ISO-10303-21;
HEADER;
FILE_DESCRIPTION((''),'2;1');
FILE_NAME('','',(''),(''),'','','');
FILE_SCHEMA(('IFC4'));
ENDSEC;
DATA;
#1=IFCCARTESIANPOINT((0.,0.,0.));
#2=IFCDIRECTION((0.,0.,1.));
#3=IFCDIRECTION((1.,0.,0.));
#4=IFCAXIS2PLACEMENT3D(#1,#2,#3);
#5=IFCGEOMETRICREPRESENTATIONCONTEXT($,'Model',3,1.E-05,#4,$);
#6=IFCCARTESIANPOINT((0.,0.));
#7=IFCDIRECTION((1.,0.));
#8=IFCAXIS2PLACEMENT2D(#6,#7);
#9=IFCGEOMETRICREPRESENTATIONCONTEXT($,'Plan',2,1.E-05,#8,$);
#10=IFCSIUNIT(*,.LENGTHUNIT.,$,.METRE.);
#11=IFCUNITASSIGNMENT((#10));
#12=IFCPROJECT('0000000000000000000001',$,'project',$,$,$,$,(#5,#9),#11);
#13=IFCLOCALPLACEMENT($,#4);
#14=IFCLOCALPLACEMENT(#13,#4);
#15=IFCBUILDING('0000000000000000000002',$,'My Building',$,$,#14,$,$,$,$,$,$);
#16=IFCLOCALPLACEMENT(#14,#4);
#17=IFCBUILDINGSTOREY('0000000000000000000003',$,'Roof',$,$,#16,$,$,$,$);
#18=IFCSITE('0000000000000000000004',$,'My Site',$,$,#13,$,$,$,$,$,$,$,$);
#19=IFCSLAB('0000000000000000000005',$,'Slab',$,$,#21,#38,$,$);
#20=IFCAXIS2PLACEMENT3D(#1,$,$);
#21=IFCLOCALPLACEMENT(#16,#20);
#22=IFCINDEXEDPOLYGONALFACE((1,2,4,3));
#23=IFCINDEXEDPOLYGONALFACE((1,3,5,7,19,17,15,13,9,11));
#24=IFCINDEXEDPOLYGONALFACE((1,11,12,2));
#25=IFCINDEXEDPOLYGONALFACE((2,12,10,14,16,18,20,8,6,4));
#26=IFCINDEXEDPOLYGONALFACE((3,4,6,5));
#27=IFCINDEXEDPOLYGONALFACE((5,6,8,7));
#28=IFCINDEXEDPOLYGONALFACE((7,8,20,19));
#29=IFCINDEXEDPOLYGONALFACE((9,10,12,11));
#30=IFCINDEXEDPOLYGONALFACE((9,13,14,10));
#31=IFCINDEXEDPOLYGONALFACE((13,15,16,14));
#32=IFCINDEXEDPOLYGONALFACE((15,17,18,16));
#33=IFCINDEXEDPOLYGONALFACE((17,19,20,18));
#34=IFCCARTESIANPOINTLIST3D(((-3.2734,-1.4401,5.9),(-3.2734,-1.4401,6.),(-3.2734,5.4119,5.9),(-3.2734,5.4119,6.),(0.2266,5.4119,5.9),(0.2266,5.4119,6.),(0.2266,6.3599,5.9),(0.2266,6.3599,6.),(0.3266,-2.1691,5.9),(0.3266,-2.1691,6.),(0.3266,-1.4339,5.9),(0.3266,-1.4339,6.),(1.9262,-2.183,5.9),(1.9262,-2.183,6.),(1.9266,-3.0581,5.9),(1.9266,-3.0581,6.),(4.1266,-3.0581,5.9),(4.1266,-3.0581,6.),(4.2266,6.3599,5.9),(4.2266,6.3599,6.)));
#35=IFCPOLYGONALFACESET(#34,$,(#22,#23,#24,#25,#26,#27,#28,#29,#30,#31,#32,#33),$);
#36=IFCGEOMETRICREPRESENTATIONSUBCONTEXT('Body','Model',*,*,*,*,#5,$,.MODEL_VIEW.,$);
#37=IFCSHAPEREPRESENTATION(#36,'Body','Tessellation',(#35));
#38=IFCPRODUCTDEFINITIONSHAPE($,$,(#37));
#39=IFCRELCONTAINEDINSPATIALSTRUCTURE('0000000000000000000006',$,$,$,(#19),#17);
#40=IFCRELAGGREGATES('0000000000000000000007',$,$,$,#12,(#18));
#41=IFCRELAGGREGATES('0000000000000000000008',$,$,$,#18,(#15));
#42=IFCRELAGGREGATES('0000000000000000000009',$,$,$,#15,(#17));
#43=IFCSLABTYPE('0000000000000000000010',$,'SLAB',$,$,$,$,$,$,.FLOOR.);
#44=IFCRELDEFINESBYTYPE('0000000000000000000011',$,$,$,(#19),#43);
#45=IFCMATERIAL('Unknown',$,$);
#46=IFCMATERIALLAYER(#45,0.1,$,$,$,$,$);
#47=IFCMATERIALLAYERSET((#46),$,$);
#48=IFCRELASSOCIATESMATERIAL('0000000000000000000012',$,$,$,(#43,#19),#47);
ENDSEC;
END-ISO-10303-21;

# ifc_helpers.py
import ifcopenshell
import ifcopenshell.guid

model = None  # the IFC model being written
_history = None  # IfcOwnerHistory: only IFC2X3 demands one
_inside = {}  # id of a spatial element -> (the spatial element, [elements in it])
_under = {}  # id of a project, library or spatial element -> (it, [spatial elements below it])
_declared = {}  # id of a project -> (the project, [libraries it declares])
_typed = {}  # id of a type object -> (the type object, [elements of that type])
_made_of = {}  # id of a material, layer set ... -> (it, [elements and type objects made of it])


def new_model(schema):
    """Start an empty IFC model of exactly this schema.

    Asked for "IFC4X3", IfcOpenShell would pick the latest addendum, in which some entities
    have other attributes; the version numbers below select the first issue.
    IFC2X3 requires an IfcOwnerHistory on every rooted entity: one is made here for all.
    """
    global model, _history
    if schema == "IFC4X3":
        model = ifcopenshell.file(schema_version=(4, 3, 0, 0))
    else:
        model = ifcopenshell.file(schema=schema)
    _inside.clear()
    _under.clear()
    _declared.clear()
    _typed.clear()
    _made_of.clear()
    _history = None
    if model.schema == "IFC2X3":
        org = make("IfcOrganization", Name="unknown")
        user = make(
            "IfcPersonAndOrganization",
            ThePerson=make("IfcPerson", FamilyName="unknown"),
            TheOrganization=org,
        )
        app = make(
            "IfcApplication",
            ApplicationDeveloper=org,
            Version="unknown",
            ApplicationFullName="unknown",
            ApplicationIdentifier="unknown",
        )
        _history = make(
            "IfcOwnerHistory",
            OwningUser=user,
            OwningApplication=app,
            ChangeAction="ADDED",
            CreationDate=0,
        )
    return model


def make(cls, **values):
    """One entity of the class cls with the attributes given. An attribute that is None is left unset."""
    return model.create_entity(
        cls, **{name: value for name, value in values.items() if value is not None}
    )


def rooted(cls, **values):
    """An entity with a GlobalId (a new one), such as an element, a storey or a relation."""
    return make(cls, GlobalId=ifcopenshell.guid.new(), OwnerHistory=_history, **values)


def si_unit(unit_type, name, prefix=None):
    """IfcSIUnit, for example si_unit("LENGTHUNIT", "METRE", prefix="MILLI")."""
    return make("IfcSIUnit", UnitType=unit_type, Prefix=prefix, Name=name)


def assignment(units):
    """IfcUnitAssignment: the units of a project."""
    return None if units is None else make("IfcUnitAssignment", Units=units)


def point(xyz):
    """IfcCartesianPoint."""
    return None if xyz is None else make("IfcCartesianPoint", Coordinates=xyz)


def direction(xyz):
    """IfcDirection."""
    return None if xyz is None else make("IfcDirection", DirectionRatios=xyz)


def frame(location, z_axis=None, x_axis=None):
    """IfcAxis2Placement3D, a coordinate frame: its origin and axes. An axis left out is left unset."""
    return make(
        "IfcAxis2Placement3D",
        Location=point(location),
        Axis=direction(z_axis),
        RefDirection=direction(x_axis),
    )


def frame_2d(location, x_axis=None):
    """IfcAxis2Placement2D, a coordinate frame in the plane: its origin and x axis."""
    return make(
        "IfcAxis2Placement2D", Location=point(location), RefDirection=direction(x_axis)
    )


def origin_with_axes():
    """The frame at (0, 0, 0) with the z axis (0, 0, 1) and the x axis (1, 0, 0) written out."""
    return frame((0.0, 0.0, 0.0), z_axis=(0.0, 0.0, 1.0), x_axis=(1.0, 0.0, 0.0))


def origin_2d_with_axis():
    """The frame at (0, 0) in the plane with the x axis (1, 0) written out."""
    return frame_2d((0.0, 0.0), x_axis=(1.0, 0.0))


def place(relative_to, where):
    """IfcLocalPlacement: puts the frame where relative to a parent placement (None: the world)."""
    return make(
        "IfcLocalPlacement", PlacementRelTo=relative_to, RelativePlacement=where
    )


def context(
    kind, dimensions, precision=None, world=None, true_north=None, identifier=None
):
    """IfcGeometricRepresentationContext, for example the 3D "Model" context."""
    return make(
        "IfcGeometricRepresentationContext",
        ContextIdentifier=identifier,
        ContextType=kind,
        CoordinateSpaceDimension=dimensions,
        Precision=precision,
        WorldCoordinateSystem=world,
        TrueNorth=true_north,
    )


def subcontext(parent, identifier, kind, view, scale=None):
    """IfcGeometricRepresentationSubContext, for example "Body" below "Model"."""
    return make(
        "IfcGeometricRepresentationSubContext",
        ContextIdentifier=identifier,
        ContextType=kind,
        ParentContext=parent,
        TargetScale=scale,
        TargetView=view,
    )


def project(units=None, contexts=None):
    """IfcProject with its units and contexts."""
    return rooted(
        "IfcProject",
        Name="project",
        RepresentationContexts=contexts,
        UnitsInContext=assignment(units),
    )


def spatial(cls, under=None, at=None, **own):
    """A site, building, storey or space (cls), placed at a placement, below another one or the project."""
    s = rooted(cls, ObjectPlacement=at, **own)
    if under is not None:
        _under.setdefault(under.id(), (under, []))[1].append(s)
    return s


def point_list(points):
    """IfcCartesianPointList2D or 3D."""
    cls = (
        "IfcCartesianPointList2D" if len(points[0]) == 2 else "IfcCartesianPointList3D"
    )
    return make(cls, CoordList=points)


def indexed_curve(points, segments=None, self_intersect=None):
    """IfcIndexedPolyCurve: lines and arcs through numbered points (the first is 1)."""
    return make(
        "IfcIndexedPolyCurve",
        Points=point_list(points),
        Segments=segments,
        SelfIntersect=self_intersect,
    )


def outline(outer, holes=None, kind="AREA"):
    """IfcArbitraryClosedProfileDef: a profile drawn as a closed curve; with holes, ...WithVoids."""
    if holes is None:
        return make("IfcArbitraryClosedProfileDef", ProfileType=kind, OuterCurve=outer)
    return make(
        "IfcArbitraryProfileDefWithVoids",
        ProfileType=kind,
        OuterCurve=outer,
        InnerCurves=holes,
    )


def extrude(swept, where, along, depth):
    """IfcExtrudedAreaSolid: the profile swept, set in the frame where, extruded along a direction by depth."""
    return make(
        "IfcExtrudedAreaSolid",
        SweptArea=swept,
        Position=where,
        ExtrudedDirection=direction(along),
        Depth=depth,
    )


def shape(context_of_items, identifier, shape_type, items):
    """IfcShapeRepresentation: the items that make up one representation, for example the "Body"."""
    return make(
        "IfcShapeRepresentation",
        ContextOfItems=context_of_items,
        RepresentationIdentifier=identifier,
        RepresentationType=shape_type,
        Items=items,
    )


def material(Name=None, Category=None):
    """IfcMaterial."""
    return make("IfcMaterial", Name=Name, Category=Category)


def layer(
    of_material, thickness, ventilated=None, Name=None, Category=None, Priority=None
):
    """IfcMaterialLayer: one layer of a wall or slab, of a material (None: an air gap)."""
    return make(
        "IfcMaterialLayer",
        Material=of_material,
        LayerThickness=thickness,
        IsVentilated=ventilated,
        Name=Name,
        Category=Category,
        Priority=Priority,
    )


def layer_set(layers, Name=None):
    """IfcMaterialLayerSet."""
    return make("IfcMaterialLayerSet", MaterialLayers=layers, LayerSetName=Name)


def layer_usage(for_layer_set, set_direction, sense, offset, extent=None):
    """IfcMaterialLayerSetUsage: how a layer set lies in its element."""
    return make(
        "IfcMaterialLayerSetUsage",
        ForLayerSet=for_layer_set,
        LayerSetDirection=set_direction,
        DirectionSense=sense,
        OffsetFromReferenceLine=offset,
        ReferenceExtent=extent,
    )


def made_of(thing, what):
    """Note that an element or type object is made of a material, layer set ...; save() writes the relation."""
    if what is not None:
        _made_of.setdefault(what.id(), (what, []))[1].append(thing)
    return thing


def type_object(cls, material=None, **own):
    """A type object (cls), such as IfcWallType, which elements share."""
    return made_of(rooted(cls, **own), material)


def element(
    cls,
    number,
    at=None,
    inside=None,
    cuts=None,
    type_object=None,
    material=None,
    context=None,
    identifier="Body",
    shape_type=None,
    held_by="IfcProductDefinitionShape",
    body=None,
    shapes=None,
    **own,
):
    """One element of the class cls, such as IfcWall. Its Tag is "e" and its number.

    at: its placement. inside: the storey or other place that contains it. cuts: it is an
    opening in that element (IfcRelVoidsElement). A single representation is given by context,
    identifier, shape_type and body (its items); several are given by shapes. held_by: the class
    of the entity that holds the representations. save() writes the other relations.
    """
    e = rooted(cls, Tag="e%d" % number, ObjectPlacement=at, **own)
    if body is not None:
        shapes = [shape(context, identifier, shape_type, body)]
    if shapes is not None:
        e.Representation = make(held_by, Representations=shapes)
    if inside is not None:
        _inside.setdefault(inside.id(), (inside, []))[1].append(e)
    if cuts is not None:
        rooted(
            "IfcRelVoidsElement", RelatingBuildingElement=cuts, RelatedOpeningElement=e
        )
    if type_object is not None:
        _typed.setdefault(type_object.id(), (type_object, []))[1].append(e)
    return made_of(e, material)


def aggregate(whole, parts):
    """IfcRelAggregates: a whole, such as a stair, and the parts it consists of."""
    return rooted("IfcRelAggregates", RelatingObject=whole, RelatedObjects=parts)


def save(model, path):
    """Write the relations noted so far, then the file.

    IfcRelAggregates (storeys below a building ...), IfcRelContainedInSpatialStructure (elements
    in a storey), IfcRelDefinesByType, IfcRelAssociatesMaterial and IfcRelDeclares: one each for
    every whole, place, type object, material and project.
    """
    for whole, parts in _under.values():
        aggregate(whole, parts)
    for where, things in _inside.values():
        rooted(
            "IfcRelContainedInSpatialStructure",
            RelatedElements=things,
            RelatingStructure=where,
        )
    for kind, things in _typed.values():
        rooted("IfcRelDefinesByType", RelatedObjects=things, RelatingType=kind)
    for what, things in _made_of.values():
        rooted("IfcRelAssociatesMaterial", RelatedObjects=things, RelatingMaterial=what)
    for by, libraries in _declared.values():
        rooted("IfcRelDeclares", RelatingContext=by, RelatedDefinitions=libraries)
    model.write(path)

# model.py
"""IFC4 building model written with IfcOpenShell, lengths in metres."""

from ifc_helpers import new_model, si_unit, frame, origin_with_axes, origin_2d_with_axis, place, context, subcontext, project, spatial, indexed_curve, outline, extrude, material, layer, layer_set, layer_usage, type_object, element, save


model = new_model("IFC4")

# Units and contexts
model_context = context("Model", 3, precision=1e-05, world=origin_with_axes())
plan_context = context("Plan", 2, precision=1e-05, world=origin_2d_with_axis())
body_context = subcontext(model_context, "Body", "Model", "MODEL_VIEW")
ifc_project = project(units=[si_unit("LENGTHUNIT", "METRE")], contexts=[model_context, plan_context])

# Site, building, storey
site_placement = place(None, origin_with_axes())
site = spatial("IfcSite", under=ifc_project, at=site_placement, Name="My Site")
building_placement = place(site_placement, origin_with_axes())
building = spatial("IfcBuilding", under=site, at=building_placement, Name="My Building")
storey_placement = place(building_placement, origin_with_axes())
storey = spatial("IfcBuildingStorey", under=building, at=storey_placement, Name="Roof")

# Slab
ifc_material = material(Name="Unknown")
ifc_layer = layer(ifc_material, 0.1)
ifc_layer_set = layer_set([ifc_layer])
ifc_layer_usage = layer_usage(ifc_layer_set, "AXIS3", "POSITIVE", -0.1)
slab_type = type_object("IfcSlabType", Name="SLAB", PredefinedType="FLOOR", material=ifc_layer_set)
slab_placement = place(storey_placement, frame((4.1266, -3.0581, 6.0), z_axis=(0.0, 0.0, 1.0), x_axis=(1.0, 0.0, 0.0)))
element("IfcSlab", 1, at=slab_placement, inside=storey, type_object=slab_type, material=ifc_layer_usage, Name="Slab", context=body_context, shape_type="SweptSolid", body=[
    extrude(outline(indexed_curve([(0.0, 0.0), (-2.2, 0.0), (-2.2004, 0.8751), (-3.8, 0.8891), (-3.8, 1.6242), (-7.4, 1.618), (-7.4, 8.47), (-3.9, 8.47), (-3.9, 9.418), (0.1, 9.418), (0.0, 0.0)])), frame((0.0, 0.0, -0.1), z_axis=(0.0, 0.0, 1.0), x_axis=(1.0, 0.0, 0.0)), (0.0, 0.0, 1.0), 0.1),
])

save(model, "model.ifc")
